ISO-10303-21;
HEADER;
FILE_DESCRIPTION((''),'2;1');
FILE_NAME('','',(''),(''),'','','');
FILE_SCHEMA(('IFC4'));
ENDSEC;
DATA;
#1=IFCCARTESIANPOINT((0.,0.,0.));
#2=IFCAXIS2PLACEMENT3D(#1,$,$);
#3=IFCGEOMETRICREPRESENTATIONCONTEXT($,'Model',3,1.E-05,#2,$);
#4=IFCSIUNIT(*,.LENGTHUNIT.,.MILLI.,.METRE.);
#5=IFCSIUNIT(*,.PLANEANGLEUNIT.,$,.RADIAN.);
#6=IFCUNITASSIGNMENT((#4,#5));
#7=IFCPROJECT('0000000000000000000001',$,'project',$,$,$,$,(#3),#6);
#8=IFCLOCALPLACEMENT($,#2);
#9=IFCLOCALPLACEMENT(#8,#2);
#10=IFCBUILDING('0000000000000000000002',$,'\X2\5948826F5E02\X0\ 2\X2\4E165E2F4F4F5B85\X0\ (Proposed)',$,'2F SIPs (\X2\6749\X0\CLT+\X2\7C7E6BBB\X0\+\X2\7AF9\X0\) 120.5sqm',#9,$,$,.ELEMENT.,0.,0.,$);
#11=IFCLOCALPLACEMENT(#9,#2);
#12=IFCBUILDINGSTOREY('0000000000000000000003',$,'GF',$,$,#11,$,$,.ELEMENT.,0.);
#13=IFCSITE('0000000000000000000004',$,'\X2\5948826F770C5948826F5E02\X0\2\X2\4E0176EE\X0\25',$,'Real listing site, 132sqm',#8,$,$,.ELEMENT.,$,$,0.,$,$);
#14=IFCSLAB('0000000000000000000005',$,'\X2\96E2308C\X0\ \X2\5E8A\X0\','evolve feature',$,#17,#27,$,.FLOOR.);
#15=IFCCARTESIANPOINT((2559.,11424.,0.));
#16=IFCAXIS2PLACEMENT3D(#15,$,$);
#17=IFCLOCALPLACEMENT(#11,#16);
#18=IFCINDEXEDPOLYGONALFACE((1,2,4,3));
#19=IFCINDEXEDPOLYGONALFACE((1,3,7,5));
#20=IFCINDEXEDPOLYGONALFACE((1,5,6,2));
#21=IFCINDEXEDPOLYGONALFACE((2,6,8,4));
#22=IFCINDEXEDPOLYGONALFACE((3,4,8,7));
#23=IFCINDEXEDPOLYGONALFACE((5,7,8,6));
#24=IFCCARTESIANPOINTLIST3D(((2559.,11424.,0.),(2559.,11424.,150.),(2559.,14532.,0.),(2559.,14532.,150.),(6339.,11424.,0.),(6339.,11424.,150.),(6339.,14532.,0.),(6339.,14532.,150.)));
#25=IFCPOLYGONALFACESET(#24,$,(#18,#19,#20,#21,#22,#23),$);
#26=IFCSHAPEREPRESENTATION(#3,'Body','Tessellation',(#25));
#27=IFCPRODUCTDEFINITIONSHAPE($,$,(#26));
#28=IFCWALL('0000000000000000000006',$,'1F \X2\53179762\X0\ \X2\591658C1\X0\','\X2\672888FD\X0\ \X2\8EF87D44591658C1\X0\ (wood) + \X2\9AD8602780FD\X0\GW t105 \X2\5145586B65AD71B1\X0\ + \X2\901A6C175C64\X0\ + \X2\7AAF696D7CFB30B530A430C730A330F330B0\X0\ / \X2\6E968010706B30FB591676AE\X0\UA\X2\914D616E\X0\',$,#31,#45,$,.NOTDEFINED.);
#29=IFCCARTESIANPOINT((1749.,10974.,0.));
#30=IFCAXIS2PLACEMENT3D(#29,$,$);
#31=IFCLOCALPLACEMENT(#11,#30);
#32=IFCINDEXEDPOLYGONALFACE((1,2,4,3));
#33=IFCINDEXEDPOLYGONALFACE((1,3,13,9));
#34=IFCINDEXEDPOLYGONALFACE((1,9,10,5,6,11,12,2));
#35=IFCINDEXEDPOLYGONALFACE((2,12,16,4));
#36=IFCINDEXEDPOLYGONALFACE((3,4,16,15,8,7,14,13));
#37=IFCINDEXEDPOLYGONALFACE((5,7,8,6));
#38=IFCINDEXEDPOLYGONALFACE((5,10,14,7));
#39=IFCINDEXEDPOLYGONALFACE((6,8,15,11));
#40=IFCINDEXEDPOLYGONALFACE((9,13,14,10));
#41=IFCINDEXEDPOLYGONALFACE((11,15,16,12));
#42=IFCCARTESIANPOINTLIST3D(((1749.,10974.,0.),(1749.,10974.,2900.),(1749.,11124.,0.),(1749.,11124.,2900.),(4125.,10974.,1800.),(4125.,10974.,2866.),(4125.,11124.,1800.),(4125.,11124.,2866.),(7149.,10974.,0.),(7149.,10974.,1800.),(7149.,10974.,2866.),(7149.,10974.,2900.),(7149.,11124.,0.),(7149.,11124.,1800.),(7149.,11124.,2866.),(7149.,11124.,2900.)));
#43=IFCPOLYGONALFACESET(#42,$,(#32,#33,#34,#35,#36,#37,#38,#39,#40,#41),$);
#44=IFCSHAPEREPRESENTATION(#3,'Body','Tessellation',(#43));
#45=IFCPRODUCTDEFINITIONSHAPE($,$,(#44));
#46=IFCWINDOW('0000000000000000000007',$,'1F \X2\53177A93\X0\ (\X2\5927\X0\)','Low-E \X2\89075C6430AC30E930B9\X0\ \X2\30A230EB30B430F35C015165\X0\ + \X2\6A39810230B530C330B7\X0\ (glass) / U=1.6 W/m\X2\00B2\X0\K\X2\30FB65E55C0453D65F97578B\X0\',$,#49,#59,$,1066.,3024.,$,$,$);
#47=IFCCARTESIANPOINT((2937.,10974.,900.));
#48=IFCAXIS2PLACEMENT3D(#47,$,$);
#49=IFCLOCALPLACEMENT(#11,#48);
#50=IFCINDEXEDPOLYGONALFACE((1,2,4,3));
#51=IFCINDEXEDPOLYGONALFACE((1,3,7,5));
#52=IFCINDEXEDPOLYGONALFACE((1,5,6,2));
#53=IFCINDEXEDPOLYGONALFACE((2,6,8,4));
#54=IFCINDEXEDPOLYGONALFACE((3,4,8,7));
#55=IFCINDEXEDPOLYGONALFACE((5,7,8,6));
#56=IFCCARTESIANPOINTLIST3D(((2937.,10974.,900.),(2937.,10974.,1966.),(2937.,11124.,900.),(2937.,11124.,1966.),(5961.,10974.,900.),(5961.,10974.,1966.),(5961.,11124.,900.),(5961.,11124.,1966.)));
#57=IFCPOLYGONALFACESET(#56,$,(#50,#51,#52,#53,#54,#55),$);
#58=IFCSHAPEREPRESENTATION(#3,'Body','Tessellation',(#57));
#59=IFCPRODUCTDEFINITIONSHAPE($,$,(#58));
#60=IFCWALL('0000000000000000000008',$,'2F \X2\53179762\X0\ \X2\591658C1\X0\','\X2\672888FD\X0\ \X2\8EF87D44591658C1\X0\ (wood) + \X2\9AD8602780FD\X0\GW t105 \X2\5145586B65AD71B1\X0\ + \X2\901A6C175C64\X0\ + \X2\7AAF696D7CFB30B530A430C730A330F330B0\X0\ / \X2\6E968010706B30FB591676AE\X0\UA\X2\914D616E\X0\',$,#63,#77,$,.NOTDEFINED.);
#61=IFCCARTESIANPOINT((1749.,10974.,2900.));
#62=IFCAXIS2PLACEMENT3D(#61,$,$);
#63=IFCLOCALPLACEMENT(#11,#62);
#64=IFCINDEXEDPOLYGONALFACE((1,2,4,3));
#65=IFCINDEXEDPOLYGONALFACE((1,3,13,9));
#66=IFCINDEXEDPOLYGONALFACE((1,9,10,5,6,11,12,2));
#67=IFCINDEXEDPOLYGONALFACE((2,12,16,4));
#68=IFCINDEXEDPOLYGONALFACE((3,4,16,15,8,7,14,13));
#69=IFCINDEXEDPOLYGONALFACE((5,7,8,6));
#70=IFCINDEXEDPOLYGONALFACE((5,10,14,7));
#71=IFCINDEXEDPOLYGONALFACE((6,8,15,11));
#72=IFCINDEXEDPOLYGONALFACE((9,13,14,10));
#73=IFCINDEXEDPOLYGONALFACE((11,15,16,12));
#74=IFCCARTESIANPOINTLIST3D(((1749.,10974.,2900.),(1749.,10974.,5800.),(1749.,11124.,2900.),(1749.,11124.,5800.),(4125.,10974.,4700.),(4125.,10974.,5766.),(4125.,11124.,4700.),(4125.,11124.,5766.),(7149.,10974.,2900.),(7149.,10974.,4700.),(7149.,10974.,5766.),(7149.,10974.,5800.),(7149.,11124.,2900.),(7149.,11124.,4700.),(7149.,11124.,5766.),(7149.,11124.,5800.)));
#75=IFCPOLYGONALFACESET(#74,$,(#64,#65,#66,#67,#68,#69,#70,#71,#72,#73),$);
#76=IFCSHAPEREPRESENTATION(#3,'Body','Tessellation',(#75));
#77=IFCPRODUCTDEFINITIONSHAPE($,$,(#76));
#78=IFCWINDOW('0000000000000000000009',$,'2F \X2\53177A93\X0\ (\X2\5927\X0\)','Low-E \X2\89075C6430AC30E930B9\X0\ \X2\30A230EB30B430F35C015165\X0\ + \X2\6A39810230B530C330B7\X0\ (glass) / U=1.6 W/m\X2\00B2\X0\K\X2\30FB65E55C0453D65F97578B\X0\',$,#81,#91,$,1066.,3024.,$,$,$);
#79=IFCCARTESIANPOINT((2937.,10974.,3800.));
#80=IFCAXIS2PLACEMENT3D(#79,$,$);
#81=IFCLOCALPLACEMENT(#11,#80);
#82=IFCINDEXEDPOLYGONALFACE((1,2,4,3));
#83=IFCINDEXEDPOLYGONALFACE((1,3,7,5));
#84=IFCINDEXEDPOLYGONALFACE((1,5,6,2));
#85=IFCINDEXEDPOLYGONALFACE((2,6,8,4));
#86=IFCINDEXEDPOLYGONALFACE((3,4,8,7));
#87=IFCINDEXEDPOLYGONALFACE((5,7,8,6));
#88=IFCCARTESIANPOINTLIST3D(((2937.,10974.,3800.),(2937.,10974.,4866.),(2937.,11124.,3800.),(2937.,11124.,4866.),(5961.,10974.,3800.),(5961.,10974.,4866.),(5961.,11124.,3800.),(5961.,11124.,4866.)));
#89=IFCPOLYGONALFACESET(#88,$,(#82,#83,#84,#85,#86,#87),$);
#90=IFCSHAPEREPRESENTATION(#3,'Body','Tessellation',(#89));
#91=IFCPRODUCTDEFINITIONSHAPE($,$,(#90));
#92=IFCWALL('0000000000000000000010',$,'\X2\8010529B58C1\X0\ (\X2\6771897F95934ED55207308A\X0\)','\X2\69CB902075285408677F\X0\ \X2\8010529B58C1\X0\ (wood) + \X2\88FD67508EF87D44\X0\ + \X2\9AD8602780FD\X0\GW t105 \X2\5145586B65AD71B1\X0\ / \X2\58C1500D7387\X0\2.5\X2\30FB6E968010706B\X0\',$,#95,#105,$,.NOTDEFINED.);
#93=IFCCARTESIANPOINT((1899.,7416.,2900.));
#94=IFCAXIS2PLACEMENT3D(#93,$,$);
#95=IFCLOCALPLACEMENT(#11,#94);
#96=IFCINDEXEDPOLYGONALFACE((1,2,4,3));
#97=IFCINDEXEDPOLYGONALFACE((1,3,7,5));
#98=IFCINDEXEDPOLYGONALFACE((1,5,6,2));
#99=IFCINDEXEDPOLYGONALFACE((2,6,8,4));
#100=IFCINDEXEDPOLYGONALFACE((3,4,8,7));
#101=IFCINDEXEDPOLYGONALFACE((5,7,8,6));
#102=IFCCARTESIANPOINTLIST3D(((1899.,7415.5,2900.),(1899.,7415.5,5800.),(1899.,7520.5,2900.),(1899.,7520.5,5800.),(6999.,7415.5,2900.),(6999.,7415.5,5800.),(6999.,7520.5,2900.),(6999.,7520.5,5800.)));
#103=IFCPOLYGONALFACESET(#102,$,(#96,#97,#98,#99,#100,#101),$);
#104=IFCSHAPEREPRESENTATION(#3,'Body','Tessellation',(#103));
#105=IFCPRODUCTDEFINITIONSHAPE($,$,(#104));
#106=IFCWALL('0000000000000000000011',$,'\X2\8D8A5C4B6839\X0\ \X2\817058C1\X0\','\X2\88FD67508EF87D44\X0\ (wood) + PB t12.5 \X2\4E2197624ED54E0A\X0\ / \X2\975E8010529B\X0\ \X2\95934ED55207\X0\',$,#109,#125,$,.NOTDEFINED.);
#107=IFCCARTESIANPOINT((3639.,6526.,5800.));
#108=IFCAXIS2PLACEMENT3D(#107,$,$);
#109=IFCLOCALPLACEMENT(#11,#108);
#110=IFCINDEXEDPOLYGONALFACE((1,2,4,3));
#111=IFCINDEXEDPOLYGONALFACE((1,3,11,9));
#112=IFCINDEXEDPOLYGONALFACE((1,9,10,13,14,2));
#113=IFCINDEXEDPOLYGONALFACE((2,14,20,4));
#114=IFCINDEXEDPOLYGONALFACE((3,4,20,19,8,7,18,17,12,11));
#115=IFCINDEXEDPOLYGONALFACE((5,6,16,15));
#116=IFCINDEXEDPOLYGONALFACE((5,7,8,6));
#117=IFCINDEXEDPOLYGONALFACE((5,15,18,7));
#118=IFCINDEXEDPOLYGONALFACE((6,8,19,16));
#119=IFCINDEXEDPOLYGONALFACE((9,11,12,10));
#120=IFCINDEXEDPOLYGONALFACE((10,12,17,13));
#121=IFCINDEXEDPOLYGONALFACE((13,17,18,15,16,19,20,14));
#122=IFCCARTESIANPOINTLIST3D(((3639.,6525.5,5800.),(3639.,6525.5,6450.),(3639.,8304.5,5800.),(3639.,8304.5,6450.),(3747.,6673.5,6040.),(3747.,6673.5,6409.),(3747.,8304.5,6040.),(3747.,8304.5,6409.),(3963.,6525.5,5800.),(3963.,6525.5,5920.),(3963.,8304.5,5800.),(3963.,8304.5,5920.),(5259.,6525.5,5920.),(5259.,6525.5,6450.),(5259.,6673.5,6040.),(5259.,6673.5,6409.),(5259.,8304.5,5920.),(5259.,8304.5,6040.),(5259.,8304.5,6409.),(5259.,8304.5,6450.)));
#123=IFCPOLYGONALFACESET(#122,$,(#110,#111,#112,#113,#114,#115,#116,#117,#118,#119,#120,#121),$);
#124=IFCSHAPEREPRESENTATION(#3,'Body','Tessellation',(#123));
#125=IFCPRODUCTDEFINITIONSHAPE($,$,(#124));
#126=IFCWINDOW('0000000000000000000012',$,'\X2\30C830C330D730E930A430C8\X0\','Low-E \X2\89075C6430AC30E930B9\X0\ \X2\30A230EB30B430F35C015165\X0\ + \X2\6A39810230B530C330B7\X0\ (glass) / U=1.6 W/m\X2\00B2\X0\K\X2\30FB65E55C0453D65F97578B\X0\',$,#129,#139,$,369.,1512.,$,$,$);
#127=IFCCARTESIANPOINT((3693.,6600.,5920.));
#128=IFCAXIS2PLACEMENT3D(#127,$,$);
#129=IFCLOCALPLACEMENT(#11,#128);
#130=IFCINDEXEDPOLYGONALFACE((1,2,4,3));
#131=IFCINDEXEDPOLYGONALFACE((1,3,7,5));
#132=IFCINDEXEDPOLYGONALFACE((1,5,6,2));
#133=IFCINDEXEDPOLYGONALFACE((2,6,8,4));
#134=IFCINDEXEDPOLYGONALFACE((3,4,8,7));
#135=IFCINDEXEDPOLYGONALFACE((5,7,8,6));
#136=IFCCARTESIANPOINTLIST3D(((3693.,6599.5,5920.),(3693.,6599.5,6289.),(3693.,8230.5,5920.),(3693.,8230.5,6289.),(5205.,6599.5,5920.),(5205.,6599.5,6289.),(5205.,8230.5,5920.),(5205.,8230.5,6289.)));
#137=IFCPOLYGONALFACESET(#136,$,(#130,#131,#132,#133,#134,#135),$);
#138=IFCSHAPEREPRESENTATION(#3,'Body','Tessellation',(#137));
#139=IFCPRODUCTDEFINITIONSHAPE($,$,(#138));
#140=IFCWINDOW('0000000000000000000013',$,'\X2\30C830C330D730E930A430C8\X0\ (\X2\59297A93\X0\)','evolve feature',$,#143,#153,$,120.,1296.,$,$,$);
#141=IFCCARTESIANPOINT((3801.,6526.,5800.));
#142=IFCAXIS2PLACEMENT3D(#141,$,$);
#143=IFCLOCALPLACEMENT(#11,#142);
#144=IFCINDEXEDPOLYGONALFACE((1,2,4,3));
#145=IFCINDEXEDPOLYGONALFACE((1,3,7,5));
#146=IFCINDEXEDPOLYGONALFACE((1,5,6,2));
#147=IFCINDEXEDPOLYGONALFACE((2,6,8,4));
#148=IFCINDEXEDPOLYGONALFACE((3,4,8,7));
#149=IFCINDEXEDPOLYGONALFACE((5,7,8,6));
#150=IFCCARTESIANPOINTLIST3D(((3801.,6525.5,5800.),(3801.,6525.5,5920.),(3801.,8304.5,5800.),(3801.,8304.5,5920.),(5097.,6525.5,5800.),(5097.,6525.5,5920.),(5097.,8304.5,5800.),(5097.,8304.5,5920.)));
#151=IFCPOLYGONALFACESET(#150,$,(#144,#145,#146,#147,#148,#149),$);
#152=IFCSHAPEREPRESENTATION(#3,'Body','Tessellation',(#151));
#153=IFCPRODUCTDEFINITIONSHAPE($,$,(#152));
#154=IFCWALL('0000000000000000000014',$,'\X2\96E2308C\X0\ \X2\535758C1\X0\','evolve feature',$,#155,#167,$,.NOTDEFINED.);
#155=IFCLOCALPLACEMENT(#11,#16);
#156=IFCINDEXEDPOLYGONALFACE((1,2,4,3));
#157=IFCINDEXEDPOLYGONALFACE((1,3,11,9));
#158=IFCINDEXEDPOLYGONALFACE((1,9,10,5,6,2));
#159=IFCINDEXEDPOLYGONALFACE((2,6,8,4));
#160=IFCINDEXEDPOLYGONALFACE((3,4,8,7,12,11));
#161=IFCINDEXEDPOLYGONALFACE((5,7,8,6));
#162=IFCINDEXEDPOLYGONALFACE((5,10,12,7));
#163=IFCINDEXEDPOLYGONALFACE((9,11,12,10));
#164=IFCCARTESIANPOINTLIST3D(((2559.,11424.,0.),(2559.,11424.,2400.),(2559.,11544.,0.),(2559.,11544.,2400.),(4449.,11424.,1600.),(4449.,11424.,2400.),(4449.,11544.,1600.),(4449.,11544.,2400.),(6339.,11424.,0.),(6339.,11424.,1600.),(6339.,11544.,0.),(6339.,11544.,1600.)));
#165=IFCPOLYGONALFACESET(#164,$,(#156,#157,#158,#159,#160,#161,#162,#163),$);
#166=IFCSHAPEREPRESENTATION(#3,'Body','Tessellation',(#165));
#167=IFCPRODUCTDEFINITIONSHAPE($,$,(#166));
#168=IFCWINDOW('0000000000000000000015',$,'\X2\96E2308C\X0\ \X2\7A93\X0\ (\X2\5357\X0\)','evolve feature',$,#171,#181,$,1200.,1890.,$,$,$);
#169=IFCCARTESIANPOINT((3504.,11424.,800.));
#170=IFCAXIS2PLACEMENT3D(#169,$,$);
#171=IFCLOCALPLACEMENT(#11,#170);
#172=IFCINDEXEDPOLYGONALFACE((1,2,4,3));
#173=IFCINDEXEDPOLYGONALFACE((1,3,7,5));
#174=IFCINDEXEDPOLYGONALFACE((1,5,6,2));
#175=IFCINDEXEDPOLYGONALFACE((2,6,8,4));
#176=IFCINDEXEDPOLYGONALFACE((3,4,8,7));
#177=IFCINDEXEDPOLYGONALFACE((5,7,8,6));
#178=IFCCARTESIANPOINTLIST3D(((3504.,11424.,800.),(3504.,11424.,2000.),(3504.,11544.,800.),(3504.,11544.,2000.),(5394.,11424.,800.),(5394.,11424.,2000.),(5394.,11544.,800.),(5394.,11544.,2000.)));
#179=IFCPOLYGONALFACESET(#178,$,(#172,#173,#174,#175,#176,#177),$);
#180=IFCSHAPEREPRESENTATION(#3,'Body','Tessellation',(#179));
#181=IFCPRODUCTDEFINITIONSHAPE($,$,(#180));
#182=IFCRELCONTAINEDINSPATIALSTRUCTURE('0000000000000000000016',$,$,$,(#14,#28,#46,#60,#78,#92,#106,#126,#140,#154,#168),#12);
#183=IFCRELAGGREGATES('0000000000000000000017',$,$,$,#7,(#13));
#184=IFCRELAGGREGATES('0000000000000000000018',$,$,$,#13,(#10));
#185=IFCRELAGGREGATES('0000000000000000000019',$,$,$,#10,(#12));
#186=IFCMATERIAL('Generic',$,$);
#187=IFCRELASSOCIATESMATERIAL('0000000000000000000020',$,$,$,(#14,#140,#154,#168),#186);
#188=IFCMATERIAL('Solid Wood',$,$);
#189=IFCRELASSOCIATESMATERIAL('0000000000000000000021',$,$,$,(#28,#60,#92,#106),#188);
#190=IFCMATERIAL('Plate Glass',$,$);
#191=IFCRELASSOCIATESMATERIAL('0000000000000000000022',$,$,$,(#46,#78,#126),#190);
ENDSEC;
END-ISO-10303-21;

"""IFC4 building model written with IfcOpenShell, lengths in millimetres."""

from ifc_helpers import new_model, si_unit, frame, frame_2d, origin, place, context, project, spatial, rectangle, extrude, material, element, fill, save


model = new_model("IFC4")

# Units and contexts
model_context = context("Model", 3, precision=1e-05, world=origin())
ifc_project = project(units=[si_unit("LENGTHUNIT", "METRE", prefix="MILLI"), si_unit("PLANEANGLEUNIT", "RADIAN")], contexts=[model_context])

# Site, building, storey
site_placement = place(None, origin())
site = spatial("IfcSite", under=ifc_project, at=site_placement, Name="奈良県奈良市2丁目25", ObjectType="Real listing site, 132sqm", CompositionType="ELEMENT", RefElevation=0.0)
building_placement = place(site_placement, origin())
building = spatial("IfcBuilding", under=site, at=building_placement, Name="奈良市 2世帯住宅 (Proposed)", ObjectType="2F SIPs (杉CLT+籾殻+竹) 120.5sqm", CompositionType="ELEMENT", ElevationOfRefHeight=0.0, ElevationOfTerrain=0.0)
storey_placement = place(building_placement, origin())
storey = spatial("IfcBuildingStorey", under=building, at=storey_placement, Name="GF", CompositionType="ELEMENT", Elevation=0.0)

# Slab
ifc_material_1 = material(Name="Generic")
slab_placement = place(storey_placement, frame((2559.0, 11424.0, 0.0)))
element("IfcSlab", 1, at=slab_placement, inside=storey, material=ifc_material_1, Name="離れ 床", Description="evolve feature", PredefinedType="FLOOR", context=model_context, shape_type="SweptSolid", body=[
    extrude(rectangle(XDim=3780.0, YDim=3108.0, at=frame_2d((1890.0, 1554.0))), frame((2559.0, 11424.0, 0.0)), (0.0, 0.0, 1.0), 150.0),
])

# Wall, opening, window
ifc_material_2 = material(Name="Solid Wood")
wall_1_placement = place(storey_placement, frame((1749.0, 10974.0, 0.0)))
wall_1 = element("IfcWall", 2, at=wall_1_placement, inside=storey, material=ifc_material_2, Name="1F 北面 外壁", Description="木製 軸組外壁 (wood) + 高性能GW t105 充填断熱 + 通気層 + 窯業系サイディング / 準耐火・外皮UA配慮", PredefinedType="NOTDEFINED", context=model_context, shape_type="SweptSolid", body=[
    extrude(rectangle(XDim=5400.0, YDim=150.0, at=frame_2d((2700.0, 75.0))), frame((1749.0, 10974.0, 0.0)), (0.0, 0.0, 1.0), 2900.0),
])
opening_1_placement = place(storey_placement, frame((2937.0, 10974.0, 900.0)))
opening_1 = element("IfcOpeningElement", 3, at=opening_1_placement, cuts=wall_1, PredefinedType="NOTDEFINED", context=model_context, shape_type="SweptSolid", body=[
    extrude(rectangle(XDim=3024.0, YDim=150.0, at=frame_2d((1512.0, 75.0))), frame((2937.0, 10974.0, 900.0)), (0.0, 0.0, 1.0), 1066.0),
])
ifc_material_3 = material(Name="Plate Glass")
window_1_placement = place(storey_placement, frame((2937.0, 10974.0, 900.0)))
window_1 = element("IfcWindow", 4, at=window_1_placement, inside=storey, material=ifc_material_3, Name="1F 北窓 (大)", Description="Low-E 複層ガラス アルゴン封入 + 樹脂サッシ (glass) / U=1.6 W/m²K・日射取得型", OverallHeight=1066.0, OverallWidth=3024.0, context=model_context, shape_type="SweptSolid", body=[
    extrude(rectangle(XDim=3024.0, YDim=150.0, at=frame_2d((1512.0, 75.0))), frame((2937.0, 10974.0, 900.0)), (0.0, 0.0, 1.0), 1066.0),
])
fill(opening_1, window_1)

# Wall, opening, window
wall_2_placement = place(storey_placement, frame((1749.0, 10974.0, 2900.0)))
wall_2 = element("IfcWall", 5, at=wall_2_placement, inside=storey, material=ifc_material_2, Name="2F 北面 外壁", Description="木製 軸組外壁 (wood) + 高性能GW t105 充填断熱 + 通気層 + 窯業系サイディング / 準耐火・外皮UA配慮", PredefinedType="NOTDEFINED", context=model_context, shape_type="SweptSolid", body=[
    extrude(rectangle(XDim=5400.0, YDim=150.0, at=frame_2d((2700.0, 75.0))), frame((1749.0, 10974.0, 2900.0)), (0.0, 0.0, 1.0), 2900.0),
])
opening_2_placement = place(storey_placement, frame((2937.0, 10974.0, 3800.0)))
opening_2 = element("IfcOpeningElement", 6, at=opening_2_placement, cuts=wall_2, PredefinedType="NOTDEFINED", context=model_context, shape_type="SweptSolid", body=[
    extrude(rectangle(XDim=3024.0, YDim=150.0, at=frame_2d((1512.0, 75.0))), frame((2937.0, 10974.0, 3800.0)), (0.0, 0.0, 1.0), 1066.0),
])
window_2_placement = place(storey_placement, frame((2937.0, 10974.0, 3800.0)))
window_2 = element("IfcWindow", 7, at=window_2_placement, inside=storey, material=ifc_material_3, Name="2F 北窓 (大)", Description="Low-E 複層ガラス アルゴン封入 + 樹脂サッシ (glass) / U=1.6 W/m²K・日射取得型", OverallHeight=1066.0, OverallWidth=3024.0, context=model_context, shape_type="SweptSolid", body=[
    extrude(rectangle(XDim=3024.0, YDim=150.0, at=frame_2d((1512.0, 75.0))), frame((2937.0, 10974.0, 3800.0)), (0.0, 0.0, 1.0), 1066.0),
])
fill(opening_2, window_2)

# Wall
wall_3_placement = place(storey_placement, frame((1899.0, 7416.0, 2900.0)))
element("IfcWall", 8, at=wall_3_placement, inside=storey, material=ifc_material_2, Name="耐力壁 (東西間仕切り)", Description="構造用合板 耐力壁 (wood) + 製材軸組 + 高性能GW t105 充填断熱 / 壁倍率2.5・準耐火", PredefinedType="NOTDEFINED", context=model_context, shape_type="SweptSolid", body=[
    extrude(rectangle(XDim=5100.0, YDim=105.0, at=frame_2d((2550.0, 52.0))), frame((1899.0, 7416.0, 2900.0)), (0.0, 0.0, 1.0), 2900.0),
])

# Wall, openings, windows
wall_4_placement = place(storey_placement, frame((3639.0, 6526.0, 5800.0)))
wall_4 = element("IfcWall", 9, at=wall_4_placement, inside=storey, material=ifc_material_2, Name="越屋根 腰壁", Description="製材軸組 (wood) + PB t12.5 両面仕上 / 非耐力 間仕切", PredefinedType="NOTDEFINED", context=model_context, shape_type="SweptSolid", body=[
    extrude(rectangle(XDim=1620.0, YDim=1779.0, at=frame_2d((810.0, 889.0))), frame((3639.0, 6526.0, 5800.0)), (0.0, 0.0, 1.0), 650.0),
])
opening_3_placement = place(storey_placement, frame((3693.0, 6600.0, 5920.0)))
opening_3 = element("IfcOpeningElement", 10, at=opening_3_placement, cuts=wall_4, PredefinedType="NOTDEFINED", context=model_context, shape_type="SweptSolid", body=[
    extrude(rectangle(XDim=1512.0, YDim=1631.0, at=frame_2d((756.0, 815.0))), frame((3693.0, 6600.0, 5920.0)), (0.0, 0.0, 1.0), 369.0),
])
opening_4_placement = place(storey_placement, frame((3801.0, 6526.0, 5800.0)))
opening_4 = element("IfcOpeningElement", 11, at=opening_4_placement, cuts=wall_4, PredefinedType="NOTDEFINED", context=model_context, shape_type="SweptSolid", body=[
    extrude(rectangle(XDim=1296.0, YDim=1779.0, at=frame_2d((648.0, 889.0))), frame((3801.0, 6526.0, 5800.0)), (0.0, 0.0, 1.0), 120.0),
])
window_3_placement = place(storey_placement, frame((3693.0, 6600.0, 5920.0)))
window_3 = element("IfcWindow", 12, at=window_3_placement, inside=storey, material=ifc_material_3, Name="トップライト", Description="Low-E 複層ガラス アルゴン封入 + 樹脂サッシ (glass) / U=1.6 W/m²K・日射取得型", OverallHeight=369.0, OverallWidth=1512.0, context=model_context, shape_type="SweptSolid", body=[
    extrude(rectangle(XDim=1512.0, YDim=1631.0, at=frame_2d((756.0, 815.0))), frame((3693.0, 6600.0, 5920.0)), (0.0, 0.0, 1.0), 369.0),
])
fill(opening_3, window_3)
window_4_placement = place(storey_placement, frame((3801.0, 6526.0, 5800.0)))
window_4 = element("IfcWindow", 13, at=window_4_placement, inside=storey, material=ifc_material_1, Name="トップライト (天窓)", Description="evolve feature", OverallHeight=120.0, OverallWidth=1296.0, context=model_context, shape_type="SweptSolid", body=[
    extrude(rectangle(XDim=1296.0, YDim=1779.0, at=frame_2d((648.0, 889.0))), frame((3801.0, 6526.0, 5800.0)), (0.0, 0.0, 1.0), 120.0),
])
fill(opening_4, window_4)

# Wall, opening, window
wall_5_placement = place(storey_placement, frame((2559.0, 11424.0, 0.0)))
wall_5 = element("IfcWall", 14, at=wall_5_placement, inside=storey, material=ifc_material_1, Name="離れ 南壁", Description="evolve feature", PredefinedType="NOTDEFINED", context=model_context, shape_type="SweptSolid", body=[
    extrude(rectangle(XDim=3780.0, YDim=120.0, at=frame_2d((1890.0, 60.0))), frame((2559.0, 11424.0, 0.0)), (0.0, 0.0, 1.0), 2400.0),
])
opening_5_placement = place(storey_placement, frame((3504.0, 11424.0, 800.0)))
opening_5 = element("IfcOpeningElement", 15, at=opening_5_placement, cuts=wall_5, PredefinedType="NOTDEFINED", context=model_context, shape_type="SweptSolid", body=[
    extrude(rectangle(XDim=1890.0, YDim=120.0, at=frame_2d((945.0, 60.0))), frame((3504.0, 11424.0, 800.0)), (0.0, 0.0, 1.0), 1200.0),
])
window_5_placement = place(storey_placement, frame((3504.0, 11424.0, 800.0)))
window_5 = element("IfcWindow", 16, at=window_5_placement, inside=storey, material=ifc_material_1, Name="離れ 窓 (南)", Description="evolve feature", OverallHeight=1200.0, OverallWidth=1890.0, context=model_context, shape_type="SweptSolid", body=[
    extrude(rectangle(XDim=1890.0, YDim=120.0, at=frame_2d((945.0, 60.0))), frame((3504.0, 11424.0, 800.0)), (0.0, 0.0, 1.0), 1200.0),
])
fill(opening_5, window_5)

save(model, "model.ifc")
